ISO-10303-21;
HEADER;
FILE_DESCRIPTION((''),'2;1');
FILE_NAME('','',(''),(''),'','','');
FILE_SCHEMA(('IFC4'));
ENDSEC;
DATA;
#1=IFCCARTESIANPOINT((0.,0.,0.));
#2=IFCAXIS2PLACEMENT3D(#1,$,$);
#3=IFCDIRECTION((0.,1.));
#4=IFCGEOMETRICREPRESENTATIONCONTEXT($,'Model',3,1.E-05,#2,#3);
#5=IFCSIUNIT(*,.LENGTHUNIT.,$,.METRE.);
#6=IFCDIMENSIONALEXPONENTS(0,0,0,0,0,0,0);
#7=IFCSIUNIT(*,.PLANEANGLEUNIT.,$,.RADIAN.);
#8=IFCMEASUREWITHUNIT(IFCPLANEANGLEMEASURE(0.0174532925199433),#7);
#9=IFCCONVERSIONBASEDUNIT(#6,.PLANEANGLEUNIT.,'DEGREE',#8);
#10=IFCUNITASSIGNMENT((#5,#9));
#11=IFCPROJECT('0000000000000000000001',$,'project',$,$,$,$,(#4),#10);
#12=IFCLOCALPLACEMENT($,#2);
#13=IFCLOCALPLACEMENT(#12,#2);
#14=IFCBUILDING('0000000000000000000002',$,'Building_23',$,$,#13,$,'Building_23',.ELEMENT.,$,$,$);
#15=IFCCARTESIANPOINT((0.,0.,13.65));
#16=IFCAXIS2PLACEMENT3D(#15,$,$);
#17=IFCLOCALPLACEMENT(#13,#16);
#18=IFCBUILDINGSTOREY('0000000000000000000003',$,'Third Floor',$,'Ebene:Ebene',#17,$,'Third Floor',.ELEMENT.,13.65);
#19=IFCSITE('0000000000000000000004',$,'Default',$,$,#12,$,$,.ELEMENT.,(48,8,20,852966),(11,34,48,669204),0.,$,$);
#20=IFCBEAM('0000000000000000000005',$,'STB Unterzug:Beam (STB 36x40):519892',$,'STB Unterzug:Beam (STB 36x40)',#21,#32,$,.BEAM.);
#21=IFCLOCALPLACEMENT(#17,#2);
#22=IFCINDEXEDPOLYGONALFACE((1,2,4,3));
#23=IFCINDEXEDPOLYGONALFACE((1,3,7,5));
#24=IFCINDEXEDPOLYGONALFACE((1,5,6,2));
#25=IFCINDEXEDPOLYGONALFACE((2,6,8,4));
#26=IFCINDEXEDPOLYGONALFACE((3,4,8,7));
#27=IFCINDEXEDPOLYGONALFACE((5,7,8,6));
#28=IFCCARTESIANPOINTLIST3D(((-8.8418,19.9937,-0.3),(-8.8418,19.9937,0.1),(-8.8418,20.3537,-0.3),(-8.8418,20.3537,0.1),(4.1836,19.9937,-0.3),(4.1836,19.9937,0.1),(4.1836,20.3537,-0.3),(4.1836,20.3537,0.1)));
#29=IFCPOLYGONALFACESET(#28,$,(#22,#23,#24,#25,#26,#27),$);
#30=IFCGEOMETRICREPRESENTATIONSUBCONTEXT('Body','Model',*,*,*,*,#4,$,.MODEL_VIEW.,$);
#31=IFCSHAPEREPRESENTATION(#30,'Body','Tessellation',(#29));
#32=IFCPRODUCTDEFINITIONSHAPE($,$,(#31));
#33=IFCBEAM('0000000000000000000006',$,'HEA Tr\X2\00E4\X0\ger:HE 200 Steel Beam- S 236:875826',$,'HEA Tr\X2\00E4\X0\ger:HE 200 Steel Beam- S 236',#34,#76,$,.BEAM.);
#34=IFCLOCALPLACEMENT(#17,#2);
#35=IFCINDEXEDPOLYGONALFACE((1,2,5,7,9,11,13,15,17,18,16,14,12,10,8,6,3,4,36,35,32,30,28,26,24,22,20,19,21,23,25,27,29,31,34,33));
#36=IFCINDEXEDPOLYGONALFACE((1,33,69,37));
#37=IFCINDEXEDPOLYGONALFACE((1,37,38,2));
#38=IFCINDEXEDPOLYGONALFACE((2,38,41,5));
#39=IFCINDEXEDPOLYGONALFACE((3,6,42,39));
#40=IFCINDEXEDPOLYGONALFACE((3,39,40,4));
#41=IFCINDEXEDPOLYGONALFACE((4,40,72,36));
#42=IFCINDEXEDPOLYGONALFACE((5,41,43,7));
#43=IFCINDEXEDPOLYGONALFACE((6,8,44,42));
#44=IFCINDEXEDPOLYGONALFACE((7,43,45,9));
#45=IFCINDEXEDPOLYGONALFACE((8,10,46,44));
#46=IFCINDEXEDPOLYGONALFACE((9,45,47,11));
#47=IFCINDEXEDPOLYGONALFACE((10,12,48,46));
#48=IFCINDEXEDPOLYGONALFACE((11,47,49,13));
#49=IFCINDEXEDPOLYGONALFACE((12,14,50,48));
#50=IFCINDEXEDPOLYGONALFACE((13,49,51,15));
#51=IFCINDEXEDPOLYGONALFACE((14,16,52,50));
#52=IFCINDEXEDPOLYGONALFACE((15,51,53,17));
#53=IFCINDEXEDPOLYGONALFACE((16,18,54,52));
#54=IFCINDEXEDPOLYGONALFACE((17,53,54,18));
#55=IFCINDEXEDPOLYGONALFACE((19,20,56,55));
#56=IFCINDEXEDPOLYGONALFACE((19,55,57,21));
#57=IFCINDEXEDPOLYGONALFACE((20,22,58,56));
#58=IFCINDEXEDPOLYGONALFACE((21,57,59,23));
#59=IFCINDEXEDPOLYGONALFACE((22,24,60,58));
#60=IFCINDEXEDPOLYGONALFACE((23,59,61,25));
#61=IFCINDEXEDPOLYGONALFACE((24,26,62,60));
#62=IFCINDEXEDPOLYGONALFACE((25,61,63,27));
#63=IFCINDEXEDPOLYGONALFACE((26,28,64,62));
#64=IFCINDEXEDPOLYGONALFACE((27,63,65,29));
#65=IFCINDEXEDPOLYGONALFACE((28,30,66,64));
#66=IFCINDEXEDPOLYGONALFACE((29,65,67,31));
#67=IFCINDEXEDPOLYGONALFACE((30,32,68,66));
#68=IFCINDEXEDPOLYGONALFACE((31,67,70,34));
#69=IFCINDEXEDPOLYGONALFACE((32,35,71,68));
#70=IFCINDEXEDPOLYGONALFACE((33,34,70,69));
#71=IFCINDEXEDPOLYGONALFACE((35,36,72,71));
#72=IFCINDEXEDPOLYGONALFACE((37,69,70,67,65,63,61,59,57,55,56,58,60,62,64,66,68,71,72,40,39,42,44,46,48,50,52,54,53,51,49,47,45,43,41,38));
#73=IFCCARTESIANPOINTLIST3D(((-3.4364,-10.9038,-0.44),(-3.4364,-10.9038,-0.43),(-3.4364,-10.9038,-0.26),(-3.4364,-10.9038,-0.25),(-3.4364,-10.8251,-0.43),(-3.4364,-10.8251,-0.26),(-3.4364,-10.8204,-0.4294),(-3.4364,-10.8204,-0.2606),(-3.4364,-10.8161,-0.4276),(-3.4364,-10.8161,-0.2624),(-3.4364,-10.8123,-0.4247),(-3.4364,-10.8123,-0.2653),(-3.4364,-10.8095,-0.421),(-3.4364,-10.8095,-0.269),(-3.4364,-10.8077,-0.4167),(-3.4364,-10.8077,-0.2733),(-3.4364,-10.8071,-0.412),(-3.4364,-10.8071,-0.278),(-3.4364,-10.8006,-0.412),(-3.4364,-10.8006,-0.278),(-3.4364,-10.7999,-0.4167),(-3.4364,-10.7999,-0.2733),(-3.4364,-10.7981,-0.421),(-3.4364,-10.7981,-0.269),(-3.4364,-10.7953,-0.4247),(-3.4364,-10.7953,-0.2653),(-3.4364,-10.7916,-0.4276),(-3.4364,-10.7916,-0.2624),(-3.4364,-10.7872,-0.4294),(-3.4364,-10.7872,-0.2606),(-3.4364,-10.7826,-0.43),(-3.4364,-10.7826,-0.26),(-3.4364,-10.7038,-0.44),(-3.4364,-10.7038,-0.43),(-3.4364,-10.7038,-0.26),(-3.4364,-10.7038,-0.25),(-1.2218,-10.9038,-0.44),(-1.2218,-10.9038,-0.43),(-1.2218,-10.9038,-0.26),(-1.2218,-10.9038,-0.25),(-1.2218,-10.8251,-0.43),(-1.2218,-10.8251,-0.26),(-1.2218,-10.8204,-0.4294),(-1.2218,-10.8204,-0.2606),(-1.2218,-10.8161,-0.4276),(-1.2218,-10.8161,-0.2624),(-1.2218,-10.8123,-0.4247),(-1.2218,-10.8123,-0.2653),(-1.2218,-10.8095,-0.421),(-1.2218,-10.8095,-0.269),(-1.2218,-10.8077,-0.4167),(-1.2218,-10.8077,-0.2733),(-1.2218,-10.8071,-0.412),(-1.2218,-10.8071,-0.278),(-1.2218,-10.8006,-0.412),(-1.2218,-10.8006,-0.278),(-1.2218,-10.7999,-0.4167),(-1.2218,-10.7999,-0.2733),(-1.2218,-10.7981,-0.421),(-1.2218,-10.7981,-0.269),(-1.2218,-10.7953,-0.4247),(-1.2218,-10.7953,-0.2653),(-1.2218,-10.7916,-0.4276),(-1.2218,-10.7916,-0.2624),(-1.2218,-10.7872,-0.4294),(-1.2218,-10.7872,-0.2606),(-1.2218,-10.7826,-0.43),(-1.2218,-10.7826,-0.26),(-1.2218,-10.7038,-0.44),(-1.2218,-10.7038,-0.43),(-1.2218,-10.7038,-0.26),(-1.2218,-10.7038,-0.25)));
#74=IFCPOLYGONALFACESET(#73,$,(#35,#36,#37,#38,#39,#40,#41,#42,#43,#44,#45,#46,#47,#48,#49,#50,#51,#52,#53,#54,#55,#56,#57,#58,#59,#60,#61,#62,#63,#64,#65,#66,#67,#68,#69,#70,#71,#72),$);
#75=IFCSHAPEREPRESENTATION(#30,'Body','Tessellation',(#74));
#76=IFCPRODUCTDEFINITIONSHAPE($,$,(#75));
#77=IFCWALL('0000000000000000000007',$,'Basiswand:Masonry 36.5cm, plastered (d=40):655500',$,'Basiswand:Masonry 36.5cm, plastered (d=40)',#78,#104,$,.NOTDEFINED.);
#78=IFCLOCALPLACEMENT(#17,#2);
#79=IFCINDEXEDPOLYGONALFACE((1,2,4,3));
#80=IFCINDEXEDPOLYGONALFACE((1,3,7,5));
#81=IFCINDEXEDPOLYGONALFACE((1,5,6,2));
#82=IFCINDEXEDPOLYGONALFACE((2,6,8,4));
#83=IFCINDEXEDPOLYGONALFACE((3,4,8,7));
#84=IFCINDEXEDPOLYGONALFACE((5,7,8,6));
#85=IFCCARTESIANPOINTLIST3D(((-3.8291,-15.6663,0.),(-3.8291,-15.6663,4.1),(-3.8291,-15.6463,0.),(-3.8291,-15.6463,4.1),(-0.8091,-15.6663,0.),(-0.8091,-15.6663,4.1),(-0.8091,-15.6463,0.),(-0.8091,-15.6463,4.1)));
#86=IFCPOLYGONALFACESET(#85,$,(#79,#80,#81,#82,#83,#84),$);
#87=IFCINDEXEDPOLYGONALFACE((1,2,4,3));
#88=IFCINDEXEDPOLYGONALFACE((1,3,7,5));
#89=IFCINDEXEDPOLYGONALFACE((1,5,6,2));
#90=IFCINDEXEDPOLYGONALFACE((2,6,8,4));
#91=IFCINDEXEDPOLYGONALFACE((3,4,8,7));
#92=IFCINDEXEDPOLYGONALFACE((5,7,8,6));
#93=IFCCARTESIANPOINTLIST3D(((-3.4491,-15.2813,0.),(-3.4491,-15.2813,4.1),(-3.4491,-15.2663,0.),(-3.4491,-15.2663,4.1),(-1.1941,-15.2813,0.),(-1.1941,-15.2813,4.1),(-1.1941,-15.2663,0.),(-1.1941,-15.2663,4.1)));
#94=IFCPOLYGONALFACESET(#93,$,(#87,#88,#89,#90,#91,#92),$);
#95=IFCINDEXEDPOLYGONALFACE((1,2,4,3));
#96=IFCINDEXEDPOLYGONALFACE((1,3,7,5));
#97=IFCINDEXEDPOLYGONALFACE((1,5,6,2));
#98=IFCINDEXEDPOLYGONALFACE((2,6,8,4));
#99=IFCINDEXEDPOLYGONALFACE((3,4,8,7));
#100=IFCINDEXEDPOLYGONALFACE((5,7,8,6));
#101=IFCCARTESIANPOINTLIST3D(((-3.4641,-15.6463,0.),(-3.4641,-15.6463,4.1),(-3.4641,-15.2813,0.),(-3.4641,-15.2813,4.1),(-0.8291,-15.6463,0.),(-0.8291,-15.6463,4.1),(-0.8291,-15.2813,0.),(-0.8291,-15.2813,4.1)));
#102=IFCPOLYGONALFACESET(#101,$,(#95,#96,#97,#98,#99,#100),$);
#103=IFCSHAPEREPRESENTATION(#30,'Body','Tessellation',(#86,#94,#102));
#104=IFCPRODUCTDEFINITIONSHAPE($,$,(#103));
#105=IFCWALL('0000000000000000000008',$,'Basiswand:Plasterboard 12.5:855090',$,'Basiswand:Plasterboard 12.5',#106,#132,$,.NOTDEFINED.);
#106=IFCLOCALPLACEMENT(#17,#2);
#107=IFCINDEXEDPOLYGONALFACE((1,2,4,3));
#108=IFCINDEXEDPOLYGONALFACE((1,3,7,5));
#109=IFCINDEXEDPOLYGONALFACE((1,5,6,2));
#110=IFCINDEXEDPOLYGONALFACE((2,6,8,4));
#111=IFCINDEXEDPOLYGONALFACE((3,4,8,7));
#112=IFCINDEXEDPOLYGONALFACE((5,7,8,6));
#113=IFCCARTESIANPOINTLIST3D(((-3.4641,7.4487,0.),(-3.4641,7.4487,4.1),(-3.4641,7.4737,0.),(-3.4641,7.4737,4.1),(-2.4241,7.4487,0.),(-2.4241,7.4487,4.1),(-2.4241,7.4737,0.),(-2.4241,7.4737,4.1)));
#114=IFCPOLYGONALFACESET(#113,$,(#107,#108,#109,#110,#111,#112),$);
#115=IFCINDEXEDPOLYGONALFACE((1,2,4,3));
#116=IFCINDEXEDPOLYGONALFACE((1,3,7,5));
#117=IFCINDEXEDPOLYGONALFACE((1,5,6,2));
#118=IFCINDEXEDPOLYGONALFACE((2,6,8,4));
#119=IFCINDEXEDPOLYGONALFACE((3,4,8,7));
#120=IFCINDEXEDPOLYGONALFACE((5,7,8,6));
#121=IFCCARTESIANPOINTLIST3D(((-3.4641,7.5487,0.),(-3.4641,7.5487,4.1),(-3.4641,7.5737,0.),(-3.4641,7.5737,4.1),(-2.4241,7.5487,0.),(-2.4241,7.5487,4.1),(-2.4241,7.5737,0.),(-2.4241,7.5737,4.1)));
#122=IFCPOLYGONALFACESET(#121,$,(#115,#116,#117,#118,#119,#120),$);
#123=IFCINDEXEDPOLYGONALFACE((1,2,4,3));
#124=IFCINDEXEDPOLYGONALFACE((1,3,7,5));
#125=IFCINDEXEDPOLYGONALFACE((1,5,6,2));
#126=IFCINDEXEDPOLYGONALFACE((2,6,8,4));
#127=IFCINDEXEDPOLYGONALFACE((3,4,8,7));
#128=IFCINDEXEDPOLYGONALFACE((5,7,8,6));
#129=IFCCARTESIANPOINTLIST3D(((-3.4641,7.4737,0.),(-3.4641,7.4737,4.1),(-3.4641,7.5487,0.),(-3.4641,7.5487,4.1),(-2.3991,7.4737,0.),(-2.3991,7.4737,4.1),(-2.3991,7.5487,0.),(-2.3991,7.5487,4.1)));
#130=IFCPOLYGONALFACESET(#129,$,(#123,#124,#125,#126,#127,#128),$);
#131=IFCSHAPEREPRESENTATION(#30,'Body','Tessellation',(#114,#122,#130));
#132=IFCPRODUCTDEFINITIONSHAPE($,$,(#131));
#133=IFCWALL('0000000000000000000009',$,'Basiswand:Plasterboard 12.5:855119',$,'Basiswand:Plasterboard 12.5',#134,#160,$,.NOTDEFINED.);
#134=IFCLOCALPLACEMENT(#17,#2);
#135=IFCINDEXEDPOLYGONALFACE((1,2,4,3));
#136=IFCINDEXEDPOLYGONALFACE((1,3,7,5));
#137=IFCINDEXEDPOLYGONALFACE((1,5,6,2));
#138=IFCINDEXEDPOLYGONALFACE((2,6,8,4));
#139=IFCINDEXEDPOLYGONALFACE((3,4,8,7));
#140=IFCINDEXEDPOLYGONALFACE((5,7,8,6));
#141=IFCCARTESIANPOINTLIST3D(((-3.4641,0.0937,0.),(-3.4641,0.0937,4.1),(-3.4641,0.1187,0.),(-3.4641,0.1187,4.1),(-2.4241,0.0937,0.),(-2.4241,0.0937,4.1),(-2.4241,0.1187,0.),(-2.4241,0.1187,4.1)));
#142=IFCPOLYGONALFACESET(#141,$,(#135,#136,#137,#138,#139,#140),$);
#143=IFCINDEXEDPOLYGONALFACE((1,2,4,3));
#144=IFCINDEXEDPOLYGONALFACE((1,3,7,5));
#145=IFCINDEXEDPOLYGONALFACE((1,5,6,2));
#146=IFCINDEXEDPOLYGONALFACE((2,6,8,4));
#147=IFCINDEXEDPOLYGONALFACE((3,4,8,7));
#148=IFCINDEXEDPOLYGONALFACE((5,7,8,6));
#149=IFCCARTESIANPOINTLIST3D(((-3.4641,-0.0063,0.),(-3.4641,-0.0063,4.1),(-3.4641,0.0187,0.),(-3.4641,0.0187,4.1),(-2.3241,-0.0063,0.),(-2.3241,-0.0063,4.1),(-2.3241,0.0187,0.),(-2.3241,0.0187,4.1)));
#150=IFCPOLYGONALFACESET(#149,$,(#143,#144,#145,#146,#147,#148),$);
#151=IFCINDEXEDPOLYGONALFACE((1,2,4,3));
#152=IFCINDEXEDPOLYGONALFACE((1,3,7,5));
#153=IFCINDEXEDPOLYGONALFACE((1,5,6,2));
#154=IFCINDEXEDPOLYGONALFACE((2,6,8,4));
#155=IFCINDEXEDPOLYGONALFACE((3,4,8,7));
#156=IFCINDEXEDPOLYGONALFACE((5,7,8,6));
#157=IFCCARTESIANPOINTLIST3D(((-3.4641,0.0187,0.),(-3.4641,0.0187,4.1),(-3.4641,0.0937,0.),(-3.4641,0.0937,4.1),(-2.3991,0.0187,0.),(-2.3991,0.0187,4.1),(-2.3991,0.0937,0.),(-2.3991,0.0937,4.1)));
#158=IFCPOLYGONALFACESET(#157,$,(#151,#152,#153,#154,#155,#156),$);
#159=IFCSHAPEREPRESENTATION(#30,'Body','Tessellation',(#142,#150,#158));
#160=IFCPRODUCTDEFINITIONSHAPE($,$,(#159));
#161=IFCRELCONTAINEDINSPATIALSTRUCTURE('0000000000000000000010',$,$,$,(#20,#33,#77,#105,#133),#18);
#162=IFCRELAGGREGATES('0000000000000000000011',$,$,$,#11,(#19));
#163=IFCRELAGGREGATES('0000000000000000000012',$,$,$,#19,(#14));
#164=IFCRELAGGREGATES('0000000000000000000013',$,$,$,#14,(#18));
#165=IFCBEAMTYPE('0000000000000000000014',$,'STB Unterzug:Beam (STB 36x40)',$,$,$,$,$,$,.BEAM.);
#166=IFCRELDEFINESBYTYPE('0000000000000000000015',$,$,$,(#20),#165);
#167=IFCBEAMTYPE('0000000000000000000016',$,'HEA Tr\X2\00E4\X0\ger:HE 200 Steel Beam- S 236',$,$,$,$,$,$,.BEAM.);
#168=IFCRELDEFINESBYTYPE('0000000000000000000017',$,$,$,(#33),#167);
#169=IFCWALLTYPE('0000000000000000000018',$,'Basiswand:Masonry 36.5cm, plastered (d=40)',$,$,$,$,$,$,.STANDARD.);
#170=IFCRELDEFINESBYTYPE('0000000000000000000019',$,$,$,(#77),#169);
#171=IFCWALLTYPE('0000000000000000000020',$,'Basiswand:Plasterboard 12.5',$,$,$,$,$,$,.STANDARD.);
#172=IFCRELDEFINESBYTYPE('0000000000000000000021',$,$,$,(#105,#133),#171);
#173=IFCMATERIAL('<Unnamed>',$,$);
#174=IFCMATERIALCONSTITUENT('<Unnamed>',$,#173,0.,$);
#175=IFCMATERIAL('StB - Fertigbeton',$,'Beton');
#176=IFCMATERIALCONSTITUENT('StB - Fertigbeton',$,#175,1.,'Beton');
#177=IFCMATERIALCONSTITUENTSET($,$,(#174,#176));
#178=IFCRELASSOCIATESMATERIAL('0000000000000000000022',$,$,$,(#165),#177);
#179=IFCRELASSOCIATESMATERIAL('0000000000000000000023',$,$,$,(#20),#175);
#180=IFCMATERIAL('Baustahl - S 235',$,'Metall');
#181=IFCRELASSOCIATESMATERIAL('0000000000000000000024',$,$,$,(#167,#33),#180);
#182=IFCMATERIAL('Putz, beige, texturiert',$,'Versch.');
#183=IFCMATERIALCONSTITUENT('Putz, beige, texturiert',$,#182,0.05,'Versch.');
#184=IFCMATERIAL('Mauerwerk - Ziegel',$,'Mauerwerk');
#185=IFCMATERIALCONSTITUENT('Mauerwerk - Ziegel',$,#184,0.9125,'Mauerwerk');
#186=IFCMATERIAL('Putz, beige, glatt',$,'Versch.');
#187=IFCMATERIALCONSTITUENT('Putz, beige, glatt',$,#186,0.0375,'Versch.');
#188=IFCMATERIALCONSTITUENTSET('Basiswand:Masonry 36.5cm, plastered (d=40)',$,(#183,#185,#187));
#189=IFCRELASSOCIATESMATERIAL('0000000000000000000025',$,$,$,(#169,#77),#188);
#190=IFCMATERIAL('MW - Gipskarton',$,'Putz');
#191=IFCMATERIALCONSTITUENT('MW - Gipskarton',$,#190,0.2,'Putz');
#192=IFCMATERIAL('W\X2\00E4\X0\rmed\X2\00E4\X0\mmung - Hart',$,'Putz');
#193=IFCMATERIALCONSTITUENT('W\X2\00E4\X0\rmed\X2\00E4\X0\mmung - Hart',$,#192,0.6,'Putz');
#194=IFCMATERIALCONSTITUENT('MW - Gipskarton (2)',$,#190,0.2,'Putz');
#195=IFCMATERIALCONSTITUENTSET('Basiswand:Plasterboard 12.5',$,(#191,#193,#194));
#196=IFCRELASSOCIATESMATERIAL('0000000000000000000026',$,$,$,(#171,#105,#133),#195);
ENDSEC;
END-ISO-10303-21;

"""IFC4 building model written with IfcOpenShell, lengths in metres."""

from ifc_helpers import new_model, entity, si_unit, converted_unit, direction, frame, origin, place, context, subcontext, project, spatial, line, arc, indexed_curve, outline, extrude, source, transform, mapped, material, constituent, constituent_set, type_object, type_shapes, element, save


model = new_model("IFC4")

# Units and contexts
model_context = context("Model", 3, precision=1e-05, world=origin(), true_north=direction((0.0, 1.0)))
body_context = subcontext(model_context, "Body", "Model", "MODEL_VIEW")
ifc_project = project(units=[si_unit("LENGTHUNIT", "METRE"), converted_unit("PLANEANGLEUNIT", "DEGREE", entity("IfcPlaneAngleMeasure", 0.0174532925199433), si_unit("PLANEANGLEUNIT", "RADIAN"), dimensions=[0, 0, 0, 0, 0, 0, 0])], contexts=[model_context])

# Site, building, storey
site_placement = place(None, origin())
site = spatial("IfcSite", under=ifc_project, at=site_placement, Name="Default", CompositionType="ELEMENT", RefLatitude=(48, 8, 20, 852966), RefLongitude=(11, 34, 48, 669204), RefElevation=0.0)
building_placement = place(site_placement, origin())
building = spatial("IfcBuilding", under=site, at=building_placement, Name="Building_23", LongName="Building_23", CompositionType="ELEMENT")
storey_placement = place(building_placement, frame((0.0, 0.0, 13.65)))
storey = spatial("IfcBuildingStorey", under=building, at=storey_placement, Name="Third Floor", ObjectType="Ebene:Ebene", LongName="Third Floor", CompositionType="ELEMENT", Elevation=13.65)

# Beams
ifc_material_1 = material(Name="StB - Fertigbeton", Category="Beton")
ifc_material_2 = material(Name="<Unnamed>")
ifc_constituent_1 = constituent(ifc_material_2, Name="<Unnamed>", fraction=0.0)
ifc_constituent_2 = constituent(ifc_material_1, Name="StB - Fertigbeton", Category="Beton", fraction=1.0)
ifc_constituent_set_1 = constituent_set(constituents=[ifc_constituent_1, ifc_constituent_2])
beam_type_1 = type_object("IfcBeamType", Name="STB Unterzug:Beam (STB 36x40)", PredefinedType="BEAM", material=ifc_constituent_set_1)
shared_shape_1 = source(origin(), body_context, "Body", "SweptSolid", [
    extrude(outline(indexed_curve([(-0.2, -0.18), (0.2, -0.18), (0.2, 0.18), (-0.2, 0.18), (-0.2, -0.18)], self_intersect=False)), frame((-8.8418, 20.1737, 13.55), z_axis=(1.0, 0.0, 0.0), x_axis=(0.0, 0.0, -1.0)), (0.0, 0.0, 1.0), 13.0254),
])
type_shapes(beam_type_1, [shared_shape_1])
beam_1_placement = place(storey_placement, frame((0.0, 0.0, -13.65)))
element("IfcBeam", 1, at=beam_1_placement, inside=storey, type_object=beam_type_1, material=ifc_material_1, Name="STB Unterzug:Beam (STB 36x40):519892", ObjectType="STB Unterzug:Beam (STB 36x40)", PredefinedType="BEAM", context=body_context, shape_type="MappedRepresentation", body=[
    mapped(shared_shape_1, transform((0.0, 0.0, 0.0), scale=1.0)),
])
ifc_material_3 = material(Name="Baustahl - S 235", Category="Metall")
beam_type_2 = type_object("IfcBeamType", Name="HEA Träger:HE 200 Steel Beam- S 236", PredefinedType="BEAM", material=ifc_material_3)
shared_shape_2 = source(origin(), body_context, "Body", "SweptSolid", [
    extrude(outline(indexed_curve([(-0.1, -0.085), (-0.1, -0.095), (0.1, -0.095), (0.1, -0.085), (0.0213, -0.085), (0.0085, -0.0797), (0.0033, -0.067), (0.0033, 0.067), (0.0085, 0.0797), (0.0213, 0.085), (0.1, 0.085), (0.1, 0.095), (-0.1, 0.095), (-0.1, 0.085), (-0.0213, 0.085), (-0.0085, 0.0797), (-0.0033, 0.067), (-0.0033, -0.067), (-0.0085, -0.0797), (-0.0213, -0.085)], segments=[line(1, 2, 3, 4, 5), arc(5, 6, 7), line(7, 8), arc(8, 9, 10), line(10, 11, 12, 13, 14, 15), arc(15, 16, 17), line(17, 18), arc(18, 19, 20), line(20, 1)], self_intersect=False)), frame((-1.1073, 0.0, 0.0), z_axis=(-1.0, 0.0, 0.0), x_axis=(0.0, -1.0, 0.0)), (0.0, 0.0, -1.0), 2.2146),
])
type_shapes(beam_type_2, [shared_shape_2])
beam_2_placement = place(storey_placement, frame((-2.3291, -10.8038, -0.345), z_axis=(0.0, 0.0, 1.0), x_axis=(-1.0, 0.0, 0.0)))
element("IfcBeam", 2, at=beam_2_placement, inside=storey, type_object=beam_type_2, material=ifc_material_3, Name="HEA Träger:HE 200 Steel Beam- S 236:875826", ObjectType="HEA Träger:HE 200 Steel Beam- S 236", PredefinedType="BEAM", context=body_context, shape_type="MappedRepresentation", body=[
    mapped(shared_shape_2, transform((0.0, 0.0, 0.0), scale=1.0)),
])

# Shared definitions
ifc_material_4 = material(Name="Wärmedämmung - Hart", Category="Putz")

# Wall
ifc_material_5 = material(Name="Putz, beige, texturiert", Category="Versch.")
ifc_constituent_3 = constituent(ifc_material_5, Name="Putz, beige, texturiert", Category="Versch.", fraction=0.05)
ifc_material_6 = material(Name="Mauerwerk - Ziegel", Category="Mauerwerk")
ifc_constituent_4 = constituent(ifc_material_6, Name="Mauerwerk - Ziegel", Category="Mauerwerk", fraction=0.9125)
ifc_material_7 = material(Name="Putz, beige, glatt", Category="Versch.")
ifc_constituent_5 = constituent(ifc_material_7, Name="Putz, beige, glatt", Category="Versch.", fraction=0.0375)
ifc_constituent_set_2 = constituent_set(constituents=[ifc_constituent_3, ifc_constituent_4, ifc_constituent_5], Name="Basiswand:Masonry 36.5cm, plastered (d=40)")
wall_type_1 = type_object("IfcWallType", Name="Basiswand:Masonry 36.5cm, plastered (d=40)", PredefinedType="STANDARD", material=ifc_constituent_set_2)
wall_1_placement = place(storey_placement, frame((-0.8091, -15.4663, 0.0), z_axis=(0.0, 0.0, 1.0), x_axis=(-1.0, 0.0, 0.0)))
element("IfcWall", 3, at=wall_1_placement, inside=storey, type_object=wall_type_1, material=ifc_constituent_set_2, Name="Basiswand:Masonry 36.5cm, plastered (d=40):655500", ObjectType="Basiswand:Masonry 36.5cm, plastered (d=40)", PredefinedType="NOTDEFINED", context=body_context, shape_type="SweptSolid", body=[
    extrude(outline(indexed_curve([(-0.01, -1.51), (0.01, -1.51), (0.01, 1.51), (-0.01, 1.51), (-0.01, -1.51)], self_intersect=False)), frame((1.51, 0.19, 0.0), z_axis=(0.0, 0.0, 1.0), x_axis=(0.0, -1.0, 0.0)), (0.0, 0.0, 1.0), 4.1),
    extrude(outline(indexed_curve([(-0.0075, -2.05), (0.0075, -2.05), (0.0075, 2.05), (-0.0075, 2.05), (-0.0075, -2.05)], self_intersect=False)), frame((2.64, -0.1925, 2.05), z_axis=(-1.0, 0.0, 0.0), x_axis=(0.0, 1.0, 0.0)), (0.0, 0.0, 1.0), 2.255),
    extrude(outline(indexed_curve([(-1.3175, -0.1825), (1.3175, -0.1825), (1.3175, 0.1825), (-1.3175, 0.1825), (-1.3175, -0.1825)], self_intersect=False)), frame((1.3375, -0.0025, 0.0)), (0.0, 0.0, 1.0), 4.1),
])

# Wall
ifc_material_8 = material(Name="MW - Gipskarton", Category="Putz")
ifc_constituent_6 = constituent(ifc_material_8, Name="MW - Gipskarton", Category="Putz", fraction=0.2)
ifc_constituent_7 = constituent(ifc_material_4, Name="Wärmedämmung - Hart", Category="Putz", fraction=0.6)
ifc_constituent_8 = constituent(ifc_material_8, Name="MW - Gipskarton (2)", Category="Putz", fraction=0.2)
ifc_constituent_set_3 = constituent_set(constituents=[ifc_constituent_6, ifc_constituent_7, ifc_constituent_8], Name="Basiswand:Plasterboard 12.5")
wall_type_2 = type_object("IfcWallType", Name="Basiswand:Plasterboard 12.5", PredefinedType="STANDARD", material=ifc_constituent_set_3)
wall_2_placement = place(storey_placement, frame((-3.4491, 7.5112, 0.0)))
element("IfcWall", 4, at=wall_2_placement, inside=storey, type_object=wall_type_2, material=ifc_constituent_set_3, Name="Basiswand:Plasterboard 12.5:855090", ObjectType="Basiswand:Plasterboard 12.5", PredefinedType="NOTDEFINED", context=body_context, shape_type="SweptSolid", body=[
    extrude(outline(indexed_curve([(-0.0125, -0.52), (0.0125, -0.52), (0.0125, 0.52), (-0.0125, 0.52), (-0.0125, -0.52)], self_intersect=False)), frame((0.505, -0.05, 0.0), z_axis=(0.0, 0.0, 1.0), x_axis=(0.0, 1.0, 0.0)), (0.0, 0.0, 1.0), 4.1),
    extrude(outline(indexed_curve([(-0.0125, -0.52), (0.0125, -0.52), (0.0125, 0.52), (-0.0125, 0.52), (-0.0125, -0.52)], self_intersect=False)), frame((0.505, 0.05, 0.0), z_axis=(0.0, 0.0, 1.0), x_axis=(0.0, -1.0, 0.0)), (0.0, 0.0, 1.0), 4.1),
    extrude(outline(indexed_curve([(-0.5325, -0.0375), (0.5325, -0.0375), (0.5325, 0.0375), (-0.5325, 0.0375), (-0.5325, -0.0375)], self_intersect=False)), frame((0.5175, 0.0, 0.0)), (0.0, 0.0, 1.0), 4.1),
])

# Wall
wall_3_placement = place(storey_placement, frame((-2.4241, 0.0562, 0.0), z_axis=(0.0, 0.0, 1.0), x_axis=(-1.0, 0.0, 0.0)))
element("IfcWall", 5, at=wall_3_placement, inside=storey, type_object=wall_type_2, material=ifc_constituent_set_3, Name="Basiswand:Plasterboard 12.5:855119", ObjectType="Basiswand:Plasterboard 12.5", PredefinedType="NOTDEFINED", context=body_context, shape_type="SweptSolid", body=[
    extrude(outline(indexed_curve([(-0.0125, -0.52), (0.0125, -0.52), (0.0125, 0.52), (-0.0125, 0.52), (-0.0125, -0.52)], self_intersect=False)), frame((0.52, -0.05, 0.0), z_axis=(0.0, 0.0, 1.0), x_axis=(0.0, 1.0, 0.0)), (0.0, 0.0, 1.0), 4.1),
    extrude(outline(indexed_curve([(-0.0125, -0.57), (0.0125, -0.57), (0.0125, 0.57), (-0.0125, 0.57), (-0.0125, -0.57)], self_intersect=False)), frame((0.47, 0.05, 0.0), z_axis=(0.0, 0.0, 1.0), x_axis=(0.0, -1.0, 0.0)), (0.0, 0.0, 1.0), 4.1),
    extrude(outline(indexed_curve([(-0.5325, -0.0375), (0.5325, -0.0375), (0.5325, 0.0375), (-0.5325, 0.0375), (-0.5325, -0.0375)], self_intersect=False)), frame((0.5075, 0.0, 0.0)), (0.0, 0.0, 1.0), 4.1),
])

save(model, "model.ifc")
